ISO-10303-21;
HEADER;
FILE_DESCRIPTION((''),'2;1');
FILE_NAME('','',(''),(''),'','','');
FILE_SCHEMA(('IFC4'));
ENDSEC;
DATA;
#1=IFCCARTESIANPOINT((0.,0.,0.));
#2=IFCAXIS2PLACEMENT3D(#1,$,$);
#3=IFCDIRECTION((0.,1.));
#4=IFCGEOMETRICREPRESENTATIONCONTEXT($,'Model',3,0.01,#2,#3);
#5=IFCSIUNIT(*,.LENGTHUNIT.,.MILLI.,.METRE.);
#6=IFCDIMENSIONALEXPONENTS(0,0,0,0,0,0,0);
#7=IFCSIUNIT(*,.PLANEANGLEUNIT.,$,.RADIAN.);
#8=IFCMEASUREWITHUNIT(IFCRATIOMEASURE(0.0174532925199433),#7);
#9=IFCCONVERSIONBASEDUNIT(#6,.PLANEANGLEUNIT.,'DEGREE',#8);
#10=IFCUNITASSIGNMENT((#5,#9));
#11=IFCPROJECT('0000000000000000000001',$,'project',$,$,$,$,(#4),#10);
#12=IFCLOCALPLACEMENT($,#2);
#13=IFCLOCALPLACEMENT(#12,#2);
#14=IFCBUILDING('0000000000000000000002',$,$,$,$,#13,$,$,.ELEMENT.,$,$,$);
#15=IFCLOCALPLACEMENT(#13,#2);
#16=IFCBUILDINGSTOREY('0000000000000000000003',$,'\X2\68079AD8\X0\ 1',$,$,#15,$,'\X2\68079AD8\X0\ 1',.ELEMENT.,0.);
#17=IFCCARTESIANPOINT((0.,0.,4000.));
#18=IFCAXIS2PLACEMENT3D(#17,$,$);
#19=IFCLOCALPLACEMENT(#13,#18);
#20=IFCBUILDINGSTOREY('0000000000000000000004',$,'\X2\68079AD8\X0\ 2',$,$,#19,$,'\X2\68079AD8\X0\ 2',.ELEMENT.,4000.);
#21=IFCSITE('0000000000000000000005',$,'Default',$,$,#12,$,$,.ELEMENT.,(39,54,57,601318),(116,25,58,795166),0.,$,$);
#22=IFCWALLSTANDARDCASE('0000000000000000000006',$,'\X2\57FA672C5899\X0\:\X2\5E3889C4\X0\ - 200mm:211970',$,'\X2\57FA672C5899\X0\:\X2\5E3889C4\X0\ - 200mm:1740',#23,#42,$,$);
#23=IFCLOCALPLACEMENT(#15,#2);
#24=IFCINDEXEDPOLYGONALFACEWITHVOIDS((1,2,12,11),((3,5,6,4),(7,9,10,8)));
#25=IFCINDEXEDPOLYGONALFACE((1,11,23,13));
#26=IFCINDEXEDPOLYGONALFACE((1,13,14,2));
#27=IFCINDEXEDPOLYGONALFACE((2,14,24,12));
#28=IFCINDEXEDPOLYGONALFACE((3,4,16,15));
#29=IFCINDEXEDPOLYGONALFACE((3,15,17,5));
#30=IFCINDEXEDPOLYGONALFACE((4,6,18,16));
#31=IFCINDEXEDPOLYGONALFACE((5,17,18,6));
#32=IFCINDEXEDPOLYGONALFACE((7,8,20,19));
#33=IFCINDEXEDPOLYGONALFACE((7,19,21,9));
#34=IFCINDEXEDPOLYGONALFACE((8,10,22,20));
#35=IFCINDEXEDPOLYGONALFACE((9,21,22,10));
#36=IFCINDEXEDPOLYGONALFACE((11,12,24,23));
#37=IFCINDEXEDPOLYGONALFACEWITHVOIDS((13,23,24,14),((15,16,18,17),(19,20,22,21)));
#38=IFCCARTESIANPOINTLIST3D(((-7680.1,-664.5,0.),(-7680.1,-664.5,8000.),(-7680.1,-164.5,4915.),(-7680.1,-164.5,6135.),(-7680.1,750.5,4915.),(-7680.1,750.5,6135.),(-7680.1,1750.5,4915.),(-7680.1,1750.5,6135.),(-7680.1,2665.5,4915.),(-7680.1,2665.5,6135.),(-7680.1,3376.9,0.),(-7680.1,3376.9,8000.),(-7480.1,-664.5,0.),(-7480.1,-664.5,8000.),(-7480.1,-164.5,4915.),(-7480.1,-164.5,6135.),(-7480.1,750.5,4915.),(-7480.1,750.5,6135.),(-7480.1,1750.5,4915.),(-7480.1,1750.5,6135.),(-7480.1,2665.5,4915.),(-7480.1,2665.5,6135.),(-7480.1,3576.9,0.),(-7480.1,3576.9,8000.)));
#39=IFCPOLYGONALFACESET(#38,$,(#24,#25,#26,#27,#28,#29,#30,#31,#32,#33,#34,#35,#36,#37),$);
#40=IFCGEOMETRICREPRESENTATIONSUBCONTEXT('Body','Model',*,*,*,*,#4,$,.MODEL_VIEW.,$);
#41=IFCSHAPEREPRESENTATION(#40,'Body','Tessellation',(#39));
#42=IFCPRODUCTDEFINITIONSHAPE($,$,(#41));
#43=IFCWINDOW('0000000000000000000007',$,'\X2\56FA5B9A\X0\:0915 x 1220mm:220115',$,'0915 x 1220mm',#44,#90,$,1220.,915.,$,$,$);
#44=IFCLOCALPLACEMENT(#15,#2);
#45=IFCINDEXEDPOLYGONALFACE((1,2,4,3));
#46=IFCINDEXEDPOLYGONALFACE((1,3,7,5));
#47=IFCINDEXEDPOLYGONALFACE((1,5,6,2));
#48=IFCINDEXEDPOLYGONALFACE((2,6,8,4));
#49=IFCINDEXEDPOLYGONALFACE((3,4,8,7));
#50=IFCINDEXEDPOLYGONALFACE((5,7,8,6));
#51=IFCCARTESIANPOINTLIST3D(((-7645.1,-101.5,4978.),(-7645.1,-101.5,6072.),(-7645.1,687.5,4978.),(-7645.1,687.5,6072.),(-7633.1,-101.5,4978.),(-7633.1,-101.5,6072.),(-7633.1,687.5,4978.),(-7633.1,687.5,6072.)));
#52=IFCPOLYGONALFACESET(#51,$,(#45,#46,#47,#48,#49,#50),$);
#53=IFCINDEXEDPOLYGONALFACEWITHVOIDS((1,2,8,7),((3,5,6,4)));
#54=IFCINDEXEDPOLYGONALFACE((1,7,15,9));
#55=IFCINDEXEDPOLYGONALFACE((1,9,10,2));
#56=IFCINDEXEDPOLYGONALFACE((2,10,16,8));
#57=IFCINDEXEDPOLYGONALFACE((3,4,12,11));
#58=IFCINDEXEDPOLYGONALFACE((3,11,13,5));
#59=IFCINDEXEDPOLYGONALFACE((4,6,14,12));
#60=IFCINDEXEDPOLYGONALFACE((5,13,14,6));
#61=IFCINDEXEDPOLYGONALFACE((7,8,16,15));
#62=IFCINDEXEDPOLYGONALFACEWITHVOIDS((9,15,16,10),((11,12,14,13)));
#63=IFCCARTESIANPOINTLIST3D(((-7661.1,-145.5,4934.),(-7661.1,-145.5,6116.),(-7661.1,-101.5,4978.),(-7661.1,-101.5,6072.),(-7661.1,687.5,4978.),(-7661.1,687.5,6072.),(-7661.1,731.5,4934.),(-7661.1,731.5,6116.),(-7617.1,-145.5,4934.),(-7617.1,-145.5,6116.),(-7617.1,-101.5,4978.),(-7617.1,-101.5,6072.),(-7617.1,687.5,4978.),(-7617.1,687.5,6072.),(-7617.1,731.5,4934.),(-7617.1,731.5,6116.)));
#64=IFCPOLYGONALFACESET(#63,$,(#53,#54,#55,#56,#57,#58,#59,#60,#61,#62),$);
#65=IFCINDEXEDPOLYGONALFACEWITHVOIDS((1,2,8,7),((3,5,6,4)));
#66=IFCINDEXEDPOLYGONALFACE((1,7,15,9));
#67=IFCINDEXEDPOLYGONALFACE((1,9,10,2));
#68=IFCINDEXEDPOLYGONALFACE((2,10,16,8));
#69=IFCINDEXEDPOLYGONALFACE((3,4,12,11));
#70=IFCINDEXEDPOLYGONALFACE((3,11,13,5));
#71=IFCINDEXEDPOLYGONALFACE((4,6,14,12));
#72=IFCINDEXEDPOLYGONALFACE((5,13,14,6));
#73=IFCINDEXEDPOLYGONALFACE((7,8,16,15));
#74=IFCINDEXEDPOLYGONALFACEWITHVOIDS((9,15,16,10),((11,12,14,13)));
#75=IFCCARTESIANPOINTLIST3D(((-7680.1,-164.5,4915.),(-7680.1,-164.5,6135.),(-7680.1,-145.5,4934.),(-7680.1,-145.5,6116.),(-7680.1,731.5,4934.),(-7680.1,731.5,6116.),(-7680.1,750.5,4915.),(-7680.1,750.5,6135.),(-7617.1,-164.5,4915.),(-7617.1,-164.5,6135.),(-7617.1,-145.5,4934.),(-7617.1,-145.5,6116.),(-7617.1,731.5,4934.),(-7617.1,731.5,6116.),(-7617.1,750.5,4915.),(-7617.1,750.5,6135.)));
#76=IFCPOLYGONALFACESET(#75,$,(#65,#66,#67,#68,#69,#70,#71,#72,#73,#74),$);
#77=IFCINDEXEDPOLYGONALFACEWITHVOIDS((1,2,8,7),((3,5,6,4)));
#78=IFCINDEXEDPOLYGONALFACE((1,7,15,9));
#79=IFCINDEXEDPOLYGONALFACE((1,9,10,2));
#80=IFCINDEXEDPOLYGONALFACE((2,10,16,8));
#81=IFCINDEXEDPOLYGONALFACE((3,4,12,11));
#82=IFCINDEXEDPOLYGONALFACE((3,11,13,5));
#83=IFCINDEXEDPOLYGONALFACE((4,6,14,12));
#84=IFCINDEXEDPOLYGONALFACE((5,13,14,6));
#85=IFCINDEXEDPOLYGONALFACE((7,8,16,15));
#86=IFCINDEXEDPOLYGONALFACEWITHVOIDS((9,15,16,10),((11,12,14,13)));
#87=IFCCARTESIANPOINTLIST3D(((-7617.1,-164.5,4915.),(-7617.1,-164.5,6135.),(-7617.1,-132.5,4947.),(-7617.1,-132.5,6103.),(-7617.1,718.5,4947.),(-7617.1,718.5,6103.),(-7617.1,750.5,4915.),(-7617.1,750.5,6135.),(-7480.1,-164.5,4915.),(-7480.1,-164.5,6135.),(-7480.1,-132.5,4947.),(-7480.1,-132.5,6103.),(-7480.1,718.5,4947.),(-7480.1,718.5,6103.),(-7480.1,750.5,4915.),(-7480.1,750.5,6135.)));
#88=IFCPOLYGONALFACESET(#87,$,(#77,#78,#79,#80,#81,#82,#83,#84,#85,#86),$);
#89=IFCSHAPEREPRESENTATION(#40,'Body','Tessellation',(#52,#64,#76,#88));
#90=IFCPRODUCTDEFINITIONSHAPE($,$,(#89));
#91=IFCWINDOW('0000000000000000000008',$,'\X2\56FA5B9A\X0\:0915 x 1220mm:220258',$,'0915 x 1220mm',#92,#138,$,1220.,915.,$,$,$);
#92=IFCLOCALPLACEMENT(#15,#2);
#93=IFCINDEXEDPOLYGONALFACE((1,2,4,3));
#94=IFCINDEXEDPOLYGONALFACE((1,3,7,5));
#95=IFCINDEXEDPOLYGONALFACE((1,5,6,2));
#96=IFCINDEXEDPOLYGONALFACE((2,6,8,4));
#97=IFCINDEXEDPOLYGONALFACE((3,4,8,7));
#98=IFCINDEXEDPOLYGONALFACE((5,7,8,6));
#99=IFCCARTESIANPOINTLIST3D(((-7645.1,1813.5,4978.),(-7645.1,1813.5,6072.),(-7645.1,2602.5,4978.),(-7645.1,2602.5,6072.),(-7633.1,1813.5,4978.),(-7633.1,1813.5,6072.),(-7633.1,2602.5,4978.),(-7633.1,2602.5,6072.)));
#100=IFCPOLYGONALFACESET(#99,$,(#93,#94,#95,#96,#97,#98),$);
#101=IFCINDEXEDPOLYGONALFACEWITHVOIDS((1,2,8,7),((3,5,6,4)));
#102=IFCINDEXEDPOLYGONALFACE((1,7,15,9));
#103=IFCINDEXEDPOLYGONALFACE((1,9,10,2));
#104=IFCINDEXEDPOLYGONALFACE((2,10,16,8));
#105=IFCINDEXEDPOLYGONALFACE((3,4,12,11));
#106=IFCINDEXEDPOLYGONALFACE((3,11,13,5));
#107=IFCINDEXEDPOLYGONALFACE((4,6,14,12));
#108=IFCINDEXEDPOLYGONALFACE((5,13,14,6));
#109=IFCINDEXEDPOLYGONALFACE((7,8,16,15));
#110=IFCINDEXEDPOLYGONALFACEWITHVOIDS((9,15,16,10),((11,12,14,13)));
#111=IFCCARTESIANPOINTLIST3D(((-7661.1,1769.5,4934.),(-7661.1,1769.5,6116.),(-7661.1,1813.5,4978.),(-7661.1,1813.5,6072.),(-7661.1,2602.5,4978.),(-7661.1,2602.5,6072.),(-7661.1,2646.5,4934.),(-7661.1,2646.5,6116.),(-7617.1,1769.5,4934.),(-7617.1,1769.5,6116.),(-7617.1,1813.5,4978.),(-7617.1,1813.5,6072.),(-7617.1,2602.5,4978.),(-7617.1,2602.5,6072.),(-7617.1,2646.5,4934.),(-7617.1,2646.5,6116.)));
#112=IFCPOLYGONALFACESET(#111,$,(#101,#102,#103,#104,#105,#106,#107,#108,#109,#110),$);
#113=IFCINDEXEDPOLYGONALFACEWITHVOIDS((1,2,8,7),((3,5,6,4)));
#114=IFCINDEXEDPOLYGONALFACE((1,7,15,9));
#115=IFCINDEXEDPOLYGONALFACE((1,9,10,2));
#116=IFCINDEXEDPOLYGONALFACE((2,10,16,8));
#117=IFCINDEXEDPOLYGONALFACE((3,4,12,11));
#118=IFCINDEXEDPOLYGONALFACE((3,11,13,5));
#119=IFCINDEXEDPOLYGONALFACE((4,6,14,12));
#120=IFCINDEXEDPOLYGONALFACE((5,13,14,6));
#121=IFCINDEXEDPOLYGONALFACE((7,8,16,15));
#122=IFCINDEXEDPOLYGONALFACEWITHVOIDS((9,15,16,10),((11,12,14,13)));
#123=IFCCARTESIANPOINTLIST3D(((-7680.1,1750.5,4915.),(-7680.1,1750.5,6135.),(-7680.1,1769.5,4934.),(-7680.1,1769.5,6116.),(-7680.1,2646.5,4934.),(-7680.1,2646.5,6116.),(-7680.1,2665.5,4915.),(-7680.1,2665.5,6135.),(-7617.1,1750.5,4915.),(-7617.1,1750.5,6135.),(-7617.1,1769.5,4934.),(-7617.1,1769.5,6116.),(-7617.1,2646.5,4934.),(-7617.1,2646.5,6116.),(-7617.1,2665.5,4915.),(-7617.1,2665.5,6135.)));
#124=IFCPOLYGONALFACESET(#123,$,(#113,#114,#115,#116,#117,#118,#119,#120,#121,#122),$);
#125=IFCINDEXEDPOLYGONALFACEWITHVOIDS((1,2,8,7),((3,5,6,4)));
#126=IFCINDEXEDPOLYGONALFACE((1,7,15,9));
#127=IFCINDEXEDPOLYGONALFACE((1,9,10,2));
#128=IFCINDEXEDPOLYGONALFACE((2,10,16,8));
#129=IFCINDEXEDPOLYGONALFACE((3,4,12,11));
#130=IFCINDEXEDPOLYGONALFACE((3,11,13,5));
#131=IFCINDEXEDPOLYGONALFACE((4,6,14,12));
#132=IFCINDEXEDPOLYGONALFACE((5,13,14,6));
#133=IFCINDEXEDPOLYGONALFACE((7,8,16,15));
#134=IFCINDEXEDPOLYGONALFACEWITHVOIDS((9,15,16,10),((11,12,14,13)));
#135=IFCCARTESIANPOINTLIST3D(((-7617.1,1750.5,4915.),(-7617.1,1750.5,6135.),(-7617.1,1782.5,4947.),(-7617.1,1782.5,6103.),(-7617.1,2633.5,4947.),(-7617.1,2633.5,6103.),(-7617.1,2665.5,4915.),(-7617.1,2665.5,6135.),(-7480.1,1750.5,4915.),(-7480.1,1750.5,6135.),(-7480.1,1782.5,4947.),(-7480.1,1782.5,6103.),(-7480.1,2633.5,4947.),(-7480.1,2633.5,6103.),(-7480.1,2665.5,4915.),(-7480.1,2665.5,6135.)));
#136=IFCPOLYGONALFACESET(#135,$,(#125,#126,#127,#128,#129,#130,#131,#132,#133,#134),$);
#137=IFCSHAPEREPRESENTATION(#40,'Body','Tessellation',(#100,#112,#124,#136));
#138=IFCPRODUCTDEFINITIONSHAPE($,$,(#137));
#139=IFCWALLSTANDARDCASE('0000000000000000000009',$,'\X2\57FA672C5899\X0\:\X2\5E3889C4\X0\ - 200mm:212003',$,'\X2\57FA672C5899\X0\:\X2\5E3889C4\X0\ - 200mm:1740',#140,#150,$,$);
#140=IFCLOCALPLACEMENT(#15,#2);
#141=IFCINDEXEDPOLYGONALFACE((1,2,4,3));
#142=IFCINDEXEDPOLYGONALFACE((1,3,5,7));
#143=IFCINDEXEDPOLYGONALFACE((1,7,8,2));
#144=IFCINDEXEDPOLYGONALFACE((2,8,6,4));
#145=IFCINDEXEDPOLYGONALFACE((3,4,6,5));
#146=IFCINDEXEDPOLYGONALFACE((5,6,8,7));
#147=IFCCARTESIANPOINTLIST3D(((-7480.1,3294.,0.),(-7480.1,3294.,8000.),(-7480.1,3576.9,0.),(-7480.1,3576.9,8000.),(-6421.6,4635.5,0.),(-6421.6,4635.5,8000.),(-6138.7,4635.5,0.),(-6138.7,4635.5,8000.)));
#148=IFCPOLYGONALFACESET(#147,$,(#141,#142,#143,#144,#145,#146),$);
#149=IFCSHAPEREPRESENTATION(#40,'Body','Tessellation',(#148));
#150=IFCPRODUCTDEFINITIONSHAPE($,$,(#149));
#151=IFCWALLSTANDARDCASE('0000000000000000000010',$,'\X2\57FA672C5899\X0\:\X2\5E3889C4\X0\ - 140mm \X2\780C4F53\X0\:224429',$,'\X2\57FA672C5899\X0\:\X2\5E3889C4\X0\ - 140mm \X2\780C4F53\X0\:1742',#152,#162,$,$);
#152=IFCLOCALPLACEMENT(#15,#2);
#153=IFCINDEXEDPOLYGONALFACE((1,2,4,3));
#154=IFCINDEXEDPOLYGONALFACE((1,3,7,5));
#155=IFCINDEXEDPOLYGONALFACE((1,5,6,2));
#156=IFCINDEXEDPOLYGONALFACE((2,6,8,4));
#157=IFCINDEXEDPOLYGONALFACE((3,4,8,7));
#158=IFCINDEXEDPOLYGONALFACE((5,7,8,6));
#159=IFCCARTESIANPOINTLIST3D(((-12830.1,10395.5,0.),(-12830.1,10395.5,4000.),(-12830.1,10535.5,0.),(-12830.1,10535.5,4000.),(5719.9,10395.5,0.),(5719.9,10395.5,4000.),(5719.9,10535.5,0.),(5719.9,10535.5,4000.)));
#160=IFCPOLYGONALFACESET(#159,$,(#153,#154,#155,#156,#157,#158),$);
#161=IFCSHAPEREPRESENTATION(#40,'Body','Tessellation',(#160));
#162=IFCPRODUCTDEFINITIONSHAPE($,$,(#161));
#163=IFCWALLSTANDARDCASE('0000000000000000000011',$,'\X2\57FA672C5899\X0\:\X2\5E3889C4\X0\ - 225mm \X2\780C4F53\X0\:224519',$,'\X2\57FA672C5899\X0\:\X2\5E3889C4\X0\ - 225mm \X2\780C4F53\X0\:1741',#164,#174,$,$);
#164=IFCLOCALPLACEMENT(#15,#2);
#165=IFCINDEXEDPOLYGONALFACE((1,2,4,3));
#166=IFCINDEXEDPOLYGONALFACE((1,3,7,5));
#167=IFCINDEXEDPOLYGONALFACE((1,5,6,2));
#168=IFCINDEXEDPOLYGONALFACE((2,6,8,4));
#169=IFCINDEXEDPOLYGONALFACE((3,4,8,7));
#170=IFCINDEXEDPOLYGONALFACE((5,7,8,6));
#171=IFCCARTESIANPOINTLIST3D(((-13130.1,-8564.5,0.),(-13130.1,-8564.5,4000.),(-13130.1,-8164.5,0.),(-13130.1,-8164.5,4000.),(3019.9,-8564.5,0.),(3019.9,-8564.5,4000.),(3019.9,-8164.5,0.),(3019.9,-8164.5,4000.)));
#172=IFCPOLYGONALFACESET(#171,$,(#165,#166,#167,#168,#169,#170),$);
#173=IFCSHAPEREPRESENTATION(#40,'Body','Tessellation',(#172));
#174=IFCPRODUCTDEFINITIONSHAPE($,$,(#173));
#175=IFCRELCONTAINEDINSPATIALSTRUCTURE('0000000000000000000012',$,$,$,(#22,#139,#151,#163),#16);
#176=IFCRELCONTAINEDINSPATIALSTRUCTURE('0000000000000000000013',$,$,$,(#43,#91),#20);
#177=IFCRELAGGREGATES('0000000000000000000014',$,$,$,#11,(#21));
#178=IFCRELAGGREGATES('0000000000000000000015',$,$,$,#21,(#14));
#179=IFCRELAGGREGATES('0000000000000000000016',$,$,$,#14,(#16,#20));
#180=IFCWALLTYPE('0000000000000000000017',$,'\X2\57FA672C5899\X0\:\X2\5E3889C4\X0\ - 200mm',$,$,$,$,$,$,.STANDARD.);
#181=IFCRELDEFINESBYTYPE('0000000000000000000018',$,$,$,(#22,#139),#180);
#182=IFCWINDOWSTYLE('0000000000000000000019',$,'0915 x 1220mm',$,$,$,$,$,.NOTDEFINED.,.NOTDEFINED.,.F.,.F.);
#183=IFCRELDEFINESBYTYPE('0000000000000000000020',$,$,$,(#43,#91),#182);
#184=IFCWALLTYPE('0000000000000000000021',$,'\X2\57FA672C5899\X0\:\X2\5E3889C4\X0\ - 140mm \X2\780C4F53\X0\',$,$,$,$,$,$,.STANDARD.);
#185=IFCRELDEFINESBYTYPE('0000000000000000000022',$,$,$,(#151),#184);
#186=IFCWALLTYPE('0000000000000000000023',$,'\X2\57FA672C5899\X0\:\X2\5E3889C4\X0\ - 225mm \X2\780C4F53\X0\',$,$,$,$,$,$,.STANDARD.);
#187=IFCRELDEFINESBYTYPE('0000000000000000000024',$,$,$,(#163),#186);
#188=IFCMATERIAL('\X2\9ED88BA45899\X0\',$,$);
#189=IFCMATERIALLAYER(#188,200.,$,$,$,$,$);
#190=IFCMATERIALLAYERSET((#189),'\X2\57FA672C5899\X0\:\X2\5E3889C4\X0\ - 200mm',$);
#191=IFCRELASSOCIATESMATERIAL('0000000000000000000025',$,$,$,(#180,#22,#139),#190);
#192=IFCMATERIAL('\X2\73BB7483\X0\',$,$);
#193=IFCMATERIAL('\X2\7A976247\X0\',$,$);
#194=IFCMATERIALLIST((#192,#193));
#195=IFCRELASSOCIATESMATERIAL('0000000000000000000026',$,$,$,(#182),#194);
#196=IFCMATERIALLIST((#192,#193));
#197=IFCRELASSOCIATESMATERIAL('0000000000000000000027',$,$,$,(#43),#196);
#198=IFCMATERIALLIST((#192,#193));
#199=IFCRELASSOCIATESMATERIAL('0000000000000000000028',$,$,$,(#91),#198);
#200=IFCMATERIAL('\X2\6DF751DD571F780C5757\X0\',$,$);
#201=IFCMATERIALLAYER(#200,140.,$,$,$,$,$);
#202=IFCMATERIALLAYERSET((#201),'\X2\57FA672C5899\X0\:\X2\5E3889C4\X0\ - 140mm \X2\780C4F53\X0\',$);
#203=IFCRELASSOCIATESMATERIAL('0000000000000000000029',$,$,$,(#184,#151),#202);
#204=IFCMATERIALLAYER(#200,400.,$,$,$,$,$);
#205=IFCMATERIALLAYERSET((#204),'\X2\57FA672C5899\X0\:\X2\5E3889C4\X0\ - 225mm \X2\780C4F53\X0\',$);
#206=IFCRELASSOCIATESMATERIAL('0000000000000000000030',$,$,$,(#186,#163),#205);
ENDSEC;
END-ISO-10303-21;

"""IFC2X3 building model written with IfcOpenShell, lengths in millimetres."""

from ifc_helpers import new_model, entity, si_unit, converted_unit, direction, frame, frame_2d, origin, place, context, subcontext, project, spatial, polyline, rectangle, outline, extrude, source, transform, mapped, material, material_list, layer, layer_set, layer_usage, type_object, type_shapes, element, fill, save


model = new_model("IFC2X3")

# Units and contexts
model_context = context("Model", 3, precision=0.01, world=origin(), true_north=direction((0.0, 1.0)))
body_context = subcontext(model_context, "Body", "Model", "MODEL_VIEW")
ifc_project = project(units=[si_unit("LENGTHUNIT", "METRE", prefix="MILLI"), converted_unit("PLANEANGLEUNIT", "DEGREE", entity("IfcRatioMeasure", 0.0174532925199433), si_unit("PLANEANGLEUNIT", "RADIAN"), dimensions=[0, 0, 0, 0, 0, 0, 0])], contexts=[model_context])

# Site, building, storey
site_placement = place(None, origin())
site = spatial("IfcSite", under=ifc_project, at=site_placement, Name="Default", CompositionType="ELEMENT", RefLatitude=(39, 54, 57, 601318), RefLongitude=(116, 25, 58, 795166), RefElevation=0.0)
building_placement = place(site_placement, origin())
building = spatial("IfcBuilding", under=site, at=building_placement, CompositionType="ELEMENT")
storey_1_placement = place(building_placement, origin())
storey_1 = spatial("IfcBuildingStorey", under=building, at=storey_1_placement, Name="标高 1", LongName="标高 1", CompositionType="ELEMENT", Elevation=0.0)

# Shared definitions
ifc_material_1 = material(Name="默认墙")
ifc_layer_1 = layer(ifc_material_1, 200.0)
ifc_layer_set_1 = layer_set([ifc_layer_1], Name="基本墙:常规 - 200mm")
wall_type_1 = type_object("IfcWallType", Name="基本墙:常规 - 200mm", PredefinedType="STANDARD", material=ifc_layer_set_1)
ifc_material_2 = material(Name="玻璃")
ifc_material_3 = material(Name="窗扇")
ifc_material_list_1 = material_list([ifc_material_2, ifc_material_3])
window_style = type_object("IfcWindowStyle", Name="0915 x 1220mm", ConstructionType="NOTDEFINED", OperationType="NOTDEFINED", ParameterTakesPrecedence=False, Sizeable=False, material=ifc_material_list_1)
shared_shape_1 = source(origin(), body_context, "Body", "SweptSolid", [
    extrude(rectangle(XDim=12.0, YDim=789.0, at=frame_2d((0.0, 0.0), x_axis=(1.0, 0.0))), frame((457.5, 159.0, 63.0), z_axis=(0.0, 0.0, 1.0), x_axis=(0.0, -1.0, 0.0)), (0.0, 0.0, 1.0), 1094.0),
    extrude(outline(polyline([(-438.5, -591.0), (438.5, -591.0), (438.5, 591.0), (-438.5, 591.0), (-438.5, -591.0)]), holes=[polyline([(-394.5, -547.0), (-394.5, 547.0), (394.5, 547.0), (394.5, -547.0), (-394.5, -547.0)])]), frame((457.5, 137.0, 610.0), z_axis=(0.0, 1.0, 0.0), x_axis=(1.0, 0.0, 0.0)), (0.0, 0.0, 1.0), 44.0),
    extrude(outline(polyline([(-457.5, -610.0), (457.5, -610.0), (457.5, 610.0), (-457.5, 610.0), (-457.5, -610.0)]), holes=[polyline([(-438.5, -591.0), (-438.5, 591.0), (438.5, 591.0), (438.5, -591.0), (-438.5, -591.0)])]), frame((457.5, 137.0, 610.0), z_axis=(0.0, 1.0, 0.0), x_axis=(1.0, 0.0, 0.0)), (0.0, 0.0, 1.0), 63.0),
    extrude(outline(polyline([(-457.5, -610.0), (457.5, -610.0), (457.5, 610.0), (-457.5, 610.0), (-457.5, -610.0)]), holes=[polyline([(-425.5, -578.0), (-425.5, 578.0), (425.5, 578.0), (425.5, -578.0), (-425.5, -578.0)])]), frame((457.5, 0.0, 610.0), z_axis=(0.0, 1.0, 0.0), x_axis=(1.0, 0.0, 0.0)), (0.0, 0.0, 1.0), 137.0),
])
type_shapes(window_style, [shared_shape_1])

# Wall, openings
ifc_layer_usage_1 = layer_usage(ifc_layer_set_1, "AXIS2", "NEGATIVE", 100.0)
wall_1_placement = place(storey_1_placement, frame((-7580.1, -664.5, 0.0), z_axis=(0.0, 0.0, 1.0), x_axis=(0.0, 1.0, 0.0)))
wall_1 = element("IfcWallStandardCase", 1, at=wall_1_placement, inside=storey_1, type_object=wall_type_1, material=ifc_layer_usage_1, Name="基本墙:常规 - 200mm:211970", ObjectType="基本墙:常规 - 200mm:1740", context=body_context, shape_type="SweptSolid", body=[
    extrude(outline(polyline([(4241.4, -100.0), (4041.4, 100.0), (0.0, 100.0), (0.0, -100.0), (3958.6, -100.0), (4241.4, -100.0)])), origin(), (0.0, 0.0, 1.0), 8000.0),
])
opening_1_placement = place(wall_1_placement, frame((500.0, -100.0, 4915.0)))
opening_1 = element("IfcOpeningElement", 2, at=opening_1_placement, cuts=wall_1, ObjectType="Opening", context=body_context, shape_type="SweptSolid", body=[
    extrude(rectangle(XDim=1220.0, YDim=915.0, at=frame_2d((610.0, 457.5), x_axis=(1.0, 0.0))), frame((0.0, 0.0, 0.0), z_axis=(0.0, 1.0, 0.0), x_axis=(0.0, 0.0, 1.0)), (0.0, 0.0, 1.0), 200.0),
])
opening_2_placement = place(wall_1_placement, frame((2415.0, -100.0, 4915.0)))
opening_2 = element("IfcOpeningElement", 3, at=opening_2_placement, cuts=wall_1, ObjectType="Opening", context=body_context, shape_type="SweptSolid", body=[
    extrude(rectangle(XDim=1220.0, YDim=915.0, at=frame_2d((610.0, 457.5), x_axis=(1.0, 0.0))), frame((0.0, 0.0, 0.0), z_axis=(0.0, 1.0, 0.0), x_axis=(0.0, 0.0, 1.0)), (0.0, 0.0, 1.0), 200.0),
])

# Shared definitions
storey_2_placement = place(building_placement, frame((0.0, 0.0, 4000.0)))
storey_2 = spatial("IfcBuildingStorey", under=building, at=storey_2_placement, Name="标高 2", LongName="标高 2", CompositionType="ELEMENT", Elevation=4000.0)

# Windows
ifc_material_list_2 = material_list([ifc_material_2, ifc_material_3])
window_1_placement = place(opening_1_placement, origin())
window_1 = element("IfcWindow", 4, at=window_1_placement, inside=storey_2, type_object=window_style, material=ifc_material_list_2, Name="固定:0915 x 1220mm:220115", ObjectType="0915 x 1220mm", OverallHeight=1220.0, OverallWidth=915.0, context=body_context, shape_type="MappedRepresentation", body=[
    mapped(shared_shape_1, transform((0.0, 0.0, 0.0), scale=1.0)),
])
fill(opening_1, window_1)
ifc_material_list_3 = material_list([ifc_material_2, ifc_material_3])
window_2_placement = place(opening_2_placement, origin())
window_2 = element("IfcWindow", 5, at=window_2_placement, inside=storey_2, type_object=window_style, material=ifc_material_list_3, Name="固定:0915 x 1220mm:220258", ObjectType="0915 x 1220mm", OverallHeight=1220.0, OverallWidth=915.0, context=body_context, shape_type="MappedRepresentation", body=[
    mapped(shared_shape_1, transform((0.0, 0.0, 0.0), scale=1.0)),
])
fill(opening_2, window_2)

# Walls
ifc_layer_usage_2 = layer_usage(ifc_layer_set_1, "AXIS2", "NEGATIVE", 100.0)
wall_2_placement = place(storey_1_placement, frame((-7550.9, 3364.7, 0.0), z_axis=(0.0, 0.0, 1.0), x_axis=(0.707107, 0.707107, 0.0)))
element("IfcWallStandardCase", 6, at=wall_2_placement, inside=storey_1, type_object=wall_type_1, material=ifc_layer_usage_2, Name="基本墙:常规 - 200mm:212003", ObjectType="基本墙:常规 - 200mm:1740", context=body_context, shape_type="SweptSolid", body=[
    extrude(outline(polyline([(1897.1, -100.0), (1697.1, 100.0), (200.0, 100.0), (0.0, -100.0), (1897.1, -100.0)])), origin(), (0.0, 0.0, 1.0), 8000.0),
])
ifc_material_4 = material(Name="混凝土砌块")
ifc_layer_2 = layer(ifc_material_4, 140.0)
ifc_layer_set_2 = layer_set([ifc_layer_2], Name="基本墙:常规 - 140mm 砌体")
ifc_layer_usage_3 = layer_usage(ifc_layer_set_2, "AXIS2", "NEGATIVE", 70.0)
wall_type_2 = type_object("IfcWallType", Name="基本墙:常规 - 140mm 砌体", PredefinedType="STANDARD", material=ifc_layer_set_2)
wall_3_placement = place(storey_1_placement, frame((-12830.1, 10465.5, 0.0)))
element("IfcWallStandardCase", 7, at=wall_3_placement, inside=storey_1, type_object=wall_type_2, material=ifc_layer_usage_3, Name="基本墙:常规 - 140mm 砌体:224429", ObjectType="基本墙:常规 - 140mm 砌体:1742", context=body_context, shape_type="SweptSolid", body=[
    extrude(rectangle(XDim=18550.0, YDim=140.0, at=frame_2d((9275.0, 0.0), x_axis=(-1.0, 0.0))), origin(), (0.0, 0.0, 1.0), 4000.0),
])
ifc_layer_3 = layer(ifc_material_4, 400.0)
ifc_layer_set_3 = layer_set([ifc_layer_3], Name="基本墙:常规 - 225mm 砌体")
ifc_layer_usage_4 = layer_usage(ifc_layer_set_3, "AXIS2", "NEGATIVE", 200.0)
wall_type_3 = type_object("IfcWallType", Name="基本墙:常规 - 225mm 砌体", PredefinedType="STANDARD", material=ifc_layer_set_3)
wall_4_placement = place(storey_1_placement, frame((3019.9, -8364.5, 0.0), z_axis=(0.0, 0.0, 1.0), x_axis=(-1.0, 0.0, 0.0)))
element("IfcWallStandardCase", 8, at=wall_4_placement, inside=storey_1, type_object=wall_type_3, material=ifc_layer_usage_4, Name="基本墙:常规 - 225mm 砌体:224519", ObjectType="基本墙:常规 - 225mm 砌体:1741", context=body_context, shape_type="SweptSolid", body=[
    extrude(rectangle(XDim=16150.0, YDim=400.0, at=frame_2d((8075.0, 0.0), x_axis=(-1.0, 0.0))), origin(), (0.0, 0.0, 1.0), 4000.0),
])

save(model, "model.ifc")
